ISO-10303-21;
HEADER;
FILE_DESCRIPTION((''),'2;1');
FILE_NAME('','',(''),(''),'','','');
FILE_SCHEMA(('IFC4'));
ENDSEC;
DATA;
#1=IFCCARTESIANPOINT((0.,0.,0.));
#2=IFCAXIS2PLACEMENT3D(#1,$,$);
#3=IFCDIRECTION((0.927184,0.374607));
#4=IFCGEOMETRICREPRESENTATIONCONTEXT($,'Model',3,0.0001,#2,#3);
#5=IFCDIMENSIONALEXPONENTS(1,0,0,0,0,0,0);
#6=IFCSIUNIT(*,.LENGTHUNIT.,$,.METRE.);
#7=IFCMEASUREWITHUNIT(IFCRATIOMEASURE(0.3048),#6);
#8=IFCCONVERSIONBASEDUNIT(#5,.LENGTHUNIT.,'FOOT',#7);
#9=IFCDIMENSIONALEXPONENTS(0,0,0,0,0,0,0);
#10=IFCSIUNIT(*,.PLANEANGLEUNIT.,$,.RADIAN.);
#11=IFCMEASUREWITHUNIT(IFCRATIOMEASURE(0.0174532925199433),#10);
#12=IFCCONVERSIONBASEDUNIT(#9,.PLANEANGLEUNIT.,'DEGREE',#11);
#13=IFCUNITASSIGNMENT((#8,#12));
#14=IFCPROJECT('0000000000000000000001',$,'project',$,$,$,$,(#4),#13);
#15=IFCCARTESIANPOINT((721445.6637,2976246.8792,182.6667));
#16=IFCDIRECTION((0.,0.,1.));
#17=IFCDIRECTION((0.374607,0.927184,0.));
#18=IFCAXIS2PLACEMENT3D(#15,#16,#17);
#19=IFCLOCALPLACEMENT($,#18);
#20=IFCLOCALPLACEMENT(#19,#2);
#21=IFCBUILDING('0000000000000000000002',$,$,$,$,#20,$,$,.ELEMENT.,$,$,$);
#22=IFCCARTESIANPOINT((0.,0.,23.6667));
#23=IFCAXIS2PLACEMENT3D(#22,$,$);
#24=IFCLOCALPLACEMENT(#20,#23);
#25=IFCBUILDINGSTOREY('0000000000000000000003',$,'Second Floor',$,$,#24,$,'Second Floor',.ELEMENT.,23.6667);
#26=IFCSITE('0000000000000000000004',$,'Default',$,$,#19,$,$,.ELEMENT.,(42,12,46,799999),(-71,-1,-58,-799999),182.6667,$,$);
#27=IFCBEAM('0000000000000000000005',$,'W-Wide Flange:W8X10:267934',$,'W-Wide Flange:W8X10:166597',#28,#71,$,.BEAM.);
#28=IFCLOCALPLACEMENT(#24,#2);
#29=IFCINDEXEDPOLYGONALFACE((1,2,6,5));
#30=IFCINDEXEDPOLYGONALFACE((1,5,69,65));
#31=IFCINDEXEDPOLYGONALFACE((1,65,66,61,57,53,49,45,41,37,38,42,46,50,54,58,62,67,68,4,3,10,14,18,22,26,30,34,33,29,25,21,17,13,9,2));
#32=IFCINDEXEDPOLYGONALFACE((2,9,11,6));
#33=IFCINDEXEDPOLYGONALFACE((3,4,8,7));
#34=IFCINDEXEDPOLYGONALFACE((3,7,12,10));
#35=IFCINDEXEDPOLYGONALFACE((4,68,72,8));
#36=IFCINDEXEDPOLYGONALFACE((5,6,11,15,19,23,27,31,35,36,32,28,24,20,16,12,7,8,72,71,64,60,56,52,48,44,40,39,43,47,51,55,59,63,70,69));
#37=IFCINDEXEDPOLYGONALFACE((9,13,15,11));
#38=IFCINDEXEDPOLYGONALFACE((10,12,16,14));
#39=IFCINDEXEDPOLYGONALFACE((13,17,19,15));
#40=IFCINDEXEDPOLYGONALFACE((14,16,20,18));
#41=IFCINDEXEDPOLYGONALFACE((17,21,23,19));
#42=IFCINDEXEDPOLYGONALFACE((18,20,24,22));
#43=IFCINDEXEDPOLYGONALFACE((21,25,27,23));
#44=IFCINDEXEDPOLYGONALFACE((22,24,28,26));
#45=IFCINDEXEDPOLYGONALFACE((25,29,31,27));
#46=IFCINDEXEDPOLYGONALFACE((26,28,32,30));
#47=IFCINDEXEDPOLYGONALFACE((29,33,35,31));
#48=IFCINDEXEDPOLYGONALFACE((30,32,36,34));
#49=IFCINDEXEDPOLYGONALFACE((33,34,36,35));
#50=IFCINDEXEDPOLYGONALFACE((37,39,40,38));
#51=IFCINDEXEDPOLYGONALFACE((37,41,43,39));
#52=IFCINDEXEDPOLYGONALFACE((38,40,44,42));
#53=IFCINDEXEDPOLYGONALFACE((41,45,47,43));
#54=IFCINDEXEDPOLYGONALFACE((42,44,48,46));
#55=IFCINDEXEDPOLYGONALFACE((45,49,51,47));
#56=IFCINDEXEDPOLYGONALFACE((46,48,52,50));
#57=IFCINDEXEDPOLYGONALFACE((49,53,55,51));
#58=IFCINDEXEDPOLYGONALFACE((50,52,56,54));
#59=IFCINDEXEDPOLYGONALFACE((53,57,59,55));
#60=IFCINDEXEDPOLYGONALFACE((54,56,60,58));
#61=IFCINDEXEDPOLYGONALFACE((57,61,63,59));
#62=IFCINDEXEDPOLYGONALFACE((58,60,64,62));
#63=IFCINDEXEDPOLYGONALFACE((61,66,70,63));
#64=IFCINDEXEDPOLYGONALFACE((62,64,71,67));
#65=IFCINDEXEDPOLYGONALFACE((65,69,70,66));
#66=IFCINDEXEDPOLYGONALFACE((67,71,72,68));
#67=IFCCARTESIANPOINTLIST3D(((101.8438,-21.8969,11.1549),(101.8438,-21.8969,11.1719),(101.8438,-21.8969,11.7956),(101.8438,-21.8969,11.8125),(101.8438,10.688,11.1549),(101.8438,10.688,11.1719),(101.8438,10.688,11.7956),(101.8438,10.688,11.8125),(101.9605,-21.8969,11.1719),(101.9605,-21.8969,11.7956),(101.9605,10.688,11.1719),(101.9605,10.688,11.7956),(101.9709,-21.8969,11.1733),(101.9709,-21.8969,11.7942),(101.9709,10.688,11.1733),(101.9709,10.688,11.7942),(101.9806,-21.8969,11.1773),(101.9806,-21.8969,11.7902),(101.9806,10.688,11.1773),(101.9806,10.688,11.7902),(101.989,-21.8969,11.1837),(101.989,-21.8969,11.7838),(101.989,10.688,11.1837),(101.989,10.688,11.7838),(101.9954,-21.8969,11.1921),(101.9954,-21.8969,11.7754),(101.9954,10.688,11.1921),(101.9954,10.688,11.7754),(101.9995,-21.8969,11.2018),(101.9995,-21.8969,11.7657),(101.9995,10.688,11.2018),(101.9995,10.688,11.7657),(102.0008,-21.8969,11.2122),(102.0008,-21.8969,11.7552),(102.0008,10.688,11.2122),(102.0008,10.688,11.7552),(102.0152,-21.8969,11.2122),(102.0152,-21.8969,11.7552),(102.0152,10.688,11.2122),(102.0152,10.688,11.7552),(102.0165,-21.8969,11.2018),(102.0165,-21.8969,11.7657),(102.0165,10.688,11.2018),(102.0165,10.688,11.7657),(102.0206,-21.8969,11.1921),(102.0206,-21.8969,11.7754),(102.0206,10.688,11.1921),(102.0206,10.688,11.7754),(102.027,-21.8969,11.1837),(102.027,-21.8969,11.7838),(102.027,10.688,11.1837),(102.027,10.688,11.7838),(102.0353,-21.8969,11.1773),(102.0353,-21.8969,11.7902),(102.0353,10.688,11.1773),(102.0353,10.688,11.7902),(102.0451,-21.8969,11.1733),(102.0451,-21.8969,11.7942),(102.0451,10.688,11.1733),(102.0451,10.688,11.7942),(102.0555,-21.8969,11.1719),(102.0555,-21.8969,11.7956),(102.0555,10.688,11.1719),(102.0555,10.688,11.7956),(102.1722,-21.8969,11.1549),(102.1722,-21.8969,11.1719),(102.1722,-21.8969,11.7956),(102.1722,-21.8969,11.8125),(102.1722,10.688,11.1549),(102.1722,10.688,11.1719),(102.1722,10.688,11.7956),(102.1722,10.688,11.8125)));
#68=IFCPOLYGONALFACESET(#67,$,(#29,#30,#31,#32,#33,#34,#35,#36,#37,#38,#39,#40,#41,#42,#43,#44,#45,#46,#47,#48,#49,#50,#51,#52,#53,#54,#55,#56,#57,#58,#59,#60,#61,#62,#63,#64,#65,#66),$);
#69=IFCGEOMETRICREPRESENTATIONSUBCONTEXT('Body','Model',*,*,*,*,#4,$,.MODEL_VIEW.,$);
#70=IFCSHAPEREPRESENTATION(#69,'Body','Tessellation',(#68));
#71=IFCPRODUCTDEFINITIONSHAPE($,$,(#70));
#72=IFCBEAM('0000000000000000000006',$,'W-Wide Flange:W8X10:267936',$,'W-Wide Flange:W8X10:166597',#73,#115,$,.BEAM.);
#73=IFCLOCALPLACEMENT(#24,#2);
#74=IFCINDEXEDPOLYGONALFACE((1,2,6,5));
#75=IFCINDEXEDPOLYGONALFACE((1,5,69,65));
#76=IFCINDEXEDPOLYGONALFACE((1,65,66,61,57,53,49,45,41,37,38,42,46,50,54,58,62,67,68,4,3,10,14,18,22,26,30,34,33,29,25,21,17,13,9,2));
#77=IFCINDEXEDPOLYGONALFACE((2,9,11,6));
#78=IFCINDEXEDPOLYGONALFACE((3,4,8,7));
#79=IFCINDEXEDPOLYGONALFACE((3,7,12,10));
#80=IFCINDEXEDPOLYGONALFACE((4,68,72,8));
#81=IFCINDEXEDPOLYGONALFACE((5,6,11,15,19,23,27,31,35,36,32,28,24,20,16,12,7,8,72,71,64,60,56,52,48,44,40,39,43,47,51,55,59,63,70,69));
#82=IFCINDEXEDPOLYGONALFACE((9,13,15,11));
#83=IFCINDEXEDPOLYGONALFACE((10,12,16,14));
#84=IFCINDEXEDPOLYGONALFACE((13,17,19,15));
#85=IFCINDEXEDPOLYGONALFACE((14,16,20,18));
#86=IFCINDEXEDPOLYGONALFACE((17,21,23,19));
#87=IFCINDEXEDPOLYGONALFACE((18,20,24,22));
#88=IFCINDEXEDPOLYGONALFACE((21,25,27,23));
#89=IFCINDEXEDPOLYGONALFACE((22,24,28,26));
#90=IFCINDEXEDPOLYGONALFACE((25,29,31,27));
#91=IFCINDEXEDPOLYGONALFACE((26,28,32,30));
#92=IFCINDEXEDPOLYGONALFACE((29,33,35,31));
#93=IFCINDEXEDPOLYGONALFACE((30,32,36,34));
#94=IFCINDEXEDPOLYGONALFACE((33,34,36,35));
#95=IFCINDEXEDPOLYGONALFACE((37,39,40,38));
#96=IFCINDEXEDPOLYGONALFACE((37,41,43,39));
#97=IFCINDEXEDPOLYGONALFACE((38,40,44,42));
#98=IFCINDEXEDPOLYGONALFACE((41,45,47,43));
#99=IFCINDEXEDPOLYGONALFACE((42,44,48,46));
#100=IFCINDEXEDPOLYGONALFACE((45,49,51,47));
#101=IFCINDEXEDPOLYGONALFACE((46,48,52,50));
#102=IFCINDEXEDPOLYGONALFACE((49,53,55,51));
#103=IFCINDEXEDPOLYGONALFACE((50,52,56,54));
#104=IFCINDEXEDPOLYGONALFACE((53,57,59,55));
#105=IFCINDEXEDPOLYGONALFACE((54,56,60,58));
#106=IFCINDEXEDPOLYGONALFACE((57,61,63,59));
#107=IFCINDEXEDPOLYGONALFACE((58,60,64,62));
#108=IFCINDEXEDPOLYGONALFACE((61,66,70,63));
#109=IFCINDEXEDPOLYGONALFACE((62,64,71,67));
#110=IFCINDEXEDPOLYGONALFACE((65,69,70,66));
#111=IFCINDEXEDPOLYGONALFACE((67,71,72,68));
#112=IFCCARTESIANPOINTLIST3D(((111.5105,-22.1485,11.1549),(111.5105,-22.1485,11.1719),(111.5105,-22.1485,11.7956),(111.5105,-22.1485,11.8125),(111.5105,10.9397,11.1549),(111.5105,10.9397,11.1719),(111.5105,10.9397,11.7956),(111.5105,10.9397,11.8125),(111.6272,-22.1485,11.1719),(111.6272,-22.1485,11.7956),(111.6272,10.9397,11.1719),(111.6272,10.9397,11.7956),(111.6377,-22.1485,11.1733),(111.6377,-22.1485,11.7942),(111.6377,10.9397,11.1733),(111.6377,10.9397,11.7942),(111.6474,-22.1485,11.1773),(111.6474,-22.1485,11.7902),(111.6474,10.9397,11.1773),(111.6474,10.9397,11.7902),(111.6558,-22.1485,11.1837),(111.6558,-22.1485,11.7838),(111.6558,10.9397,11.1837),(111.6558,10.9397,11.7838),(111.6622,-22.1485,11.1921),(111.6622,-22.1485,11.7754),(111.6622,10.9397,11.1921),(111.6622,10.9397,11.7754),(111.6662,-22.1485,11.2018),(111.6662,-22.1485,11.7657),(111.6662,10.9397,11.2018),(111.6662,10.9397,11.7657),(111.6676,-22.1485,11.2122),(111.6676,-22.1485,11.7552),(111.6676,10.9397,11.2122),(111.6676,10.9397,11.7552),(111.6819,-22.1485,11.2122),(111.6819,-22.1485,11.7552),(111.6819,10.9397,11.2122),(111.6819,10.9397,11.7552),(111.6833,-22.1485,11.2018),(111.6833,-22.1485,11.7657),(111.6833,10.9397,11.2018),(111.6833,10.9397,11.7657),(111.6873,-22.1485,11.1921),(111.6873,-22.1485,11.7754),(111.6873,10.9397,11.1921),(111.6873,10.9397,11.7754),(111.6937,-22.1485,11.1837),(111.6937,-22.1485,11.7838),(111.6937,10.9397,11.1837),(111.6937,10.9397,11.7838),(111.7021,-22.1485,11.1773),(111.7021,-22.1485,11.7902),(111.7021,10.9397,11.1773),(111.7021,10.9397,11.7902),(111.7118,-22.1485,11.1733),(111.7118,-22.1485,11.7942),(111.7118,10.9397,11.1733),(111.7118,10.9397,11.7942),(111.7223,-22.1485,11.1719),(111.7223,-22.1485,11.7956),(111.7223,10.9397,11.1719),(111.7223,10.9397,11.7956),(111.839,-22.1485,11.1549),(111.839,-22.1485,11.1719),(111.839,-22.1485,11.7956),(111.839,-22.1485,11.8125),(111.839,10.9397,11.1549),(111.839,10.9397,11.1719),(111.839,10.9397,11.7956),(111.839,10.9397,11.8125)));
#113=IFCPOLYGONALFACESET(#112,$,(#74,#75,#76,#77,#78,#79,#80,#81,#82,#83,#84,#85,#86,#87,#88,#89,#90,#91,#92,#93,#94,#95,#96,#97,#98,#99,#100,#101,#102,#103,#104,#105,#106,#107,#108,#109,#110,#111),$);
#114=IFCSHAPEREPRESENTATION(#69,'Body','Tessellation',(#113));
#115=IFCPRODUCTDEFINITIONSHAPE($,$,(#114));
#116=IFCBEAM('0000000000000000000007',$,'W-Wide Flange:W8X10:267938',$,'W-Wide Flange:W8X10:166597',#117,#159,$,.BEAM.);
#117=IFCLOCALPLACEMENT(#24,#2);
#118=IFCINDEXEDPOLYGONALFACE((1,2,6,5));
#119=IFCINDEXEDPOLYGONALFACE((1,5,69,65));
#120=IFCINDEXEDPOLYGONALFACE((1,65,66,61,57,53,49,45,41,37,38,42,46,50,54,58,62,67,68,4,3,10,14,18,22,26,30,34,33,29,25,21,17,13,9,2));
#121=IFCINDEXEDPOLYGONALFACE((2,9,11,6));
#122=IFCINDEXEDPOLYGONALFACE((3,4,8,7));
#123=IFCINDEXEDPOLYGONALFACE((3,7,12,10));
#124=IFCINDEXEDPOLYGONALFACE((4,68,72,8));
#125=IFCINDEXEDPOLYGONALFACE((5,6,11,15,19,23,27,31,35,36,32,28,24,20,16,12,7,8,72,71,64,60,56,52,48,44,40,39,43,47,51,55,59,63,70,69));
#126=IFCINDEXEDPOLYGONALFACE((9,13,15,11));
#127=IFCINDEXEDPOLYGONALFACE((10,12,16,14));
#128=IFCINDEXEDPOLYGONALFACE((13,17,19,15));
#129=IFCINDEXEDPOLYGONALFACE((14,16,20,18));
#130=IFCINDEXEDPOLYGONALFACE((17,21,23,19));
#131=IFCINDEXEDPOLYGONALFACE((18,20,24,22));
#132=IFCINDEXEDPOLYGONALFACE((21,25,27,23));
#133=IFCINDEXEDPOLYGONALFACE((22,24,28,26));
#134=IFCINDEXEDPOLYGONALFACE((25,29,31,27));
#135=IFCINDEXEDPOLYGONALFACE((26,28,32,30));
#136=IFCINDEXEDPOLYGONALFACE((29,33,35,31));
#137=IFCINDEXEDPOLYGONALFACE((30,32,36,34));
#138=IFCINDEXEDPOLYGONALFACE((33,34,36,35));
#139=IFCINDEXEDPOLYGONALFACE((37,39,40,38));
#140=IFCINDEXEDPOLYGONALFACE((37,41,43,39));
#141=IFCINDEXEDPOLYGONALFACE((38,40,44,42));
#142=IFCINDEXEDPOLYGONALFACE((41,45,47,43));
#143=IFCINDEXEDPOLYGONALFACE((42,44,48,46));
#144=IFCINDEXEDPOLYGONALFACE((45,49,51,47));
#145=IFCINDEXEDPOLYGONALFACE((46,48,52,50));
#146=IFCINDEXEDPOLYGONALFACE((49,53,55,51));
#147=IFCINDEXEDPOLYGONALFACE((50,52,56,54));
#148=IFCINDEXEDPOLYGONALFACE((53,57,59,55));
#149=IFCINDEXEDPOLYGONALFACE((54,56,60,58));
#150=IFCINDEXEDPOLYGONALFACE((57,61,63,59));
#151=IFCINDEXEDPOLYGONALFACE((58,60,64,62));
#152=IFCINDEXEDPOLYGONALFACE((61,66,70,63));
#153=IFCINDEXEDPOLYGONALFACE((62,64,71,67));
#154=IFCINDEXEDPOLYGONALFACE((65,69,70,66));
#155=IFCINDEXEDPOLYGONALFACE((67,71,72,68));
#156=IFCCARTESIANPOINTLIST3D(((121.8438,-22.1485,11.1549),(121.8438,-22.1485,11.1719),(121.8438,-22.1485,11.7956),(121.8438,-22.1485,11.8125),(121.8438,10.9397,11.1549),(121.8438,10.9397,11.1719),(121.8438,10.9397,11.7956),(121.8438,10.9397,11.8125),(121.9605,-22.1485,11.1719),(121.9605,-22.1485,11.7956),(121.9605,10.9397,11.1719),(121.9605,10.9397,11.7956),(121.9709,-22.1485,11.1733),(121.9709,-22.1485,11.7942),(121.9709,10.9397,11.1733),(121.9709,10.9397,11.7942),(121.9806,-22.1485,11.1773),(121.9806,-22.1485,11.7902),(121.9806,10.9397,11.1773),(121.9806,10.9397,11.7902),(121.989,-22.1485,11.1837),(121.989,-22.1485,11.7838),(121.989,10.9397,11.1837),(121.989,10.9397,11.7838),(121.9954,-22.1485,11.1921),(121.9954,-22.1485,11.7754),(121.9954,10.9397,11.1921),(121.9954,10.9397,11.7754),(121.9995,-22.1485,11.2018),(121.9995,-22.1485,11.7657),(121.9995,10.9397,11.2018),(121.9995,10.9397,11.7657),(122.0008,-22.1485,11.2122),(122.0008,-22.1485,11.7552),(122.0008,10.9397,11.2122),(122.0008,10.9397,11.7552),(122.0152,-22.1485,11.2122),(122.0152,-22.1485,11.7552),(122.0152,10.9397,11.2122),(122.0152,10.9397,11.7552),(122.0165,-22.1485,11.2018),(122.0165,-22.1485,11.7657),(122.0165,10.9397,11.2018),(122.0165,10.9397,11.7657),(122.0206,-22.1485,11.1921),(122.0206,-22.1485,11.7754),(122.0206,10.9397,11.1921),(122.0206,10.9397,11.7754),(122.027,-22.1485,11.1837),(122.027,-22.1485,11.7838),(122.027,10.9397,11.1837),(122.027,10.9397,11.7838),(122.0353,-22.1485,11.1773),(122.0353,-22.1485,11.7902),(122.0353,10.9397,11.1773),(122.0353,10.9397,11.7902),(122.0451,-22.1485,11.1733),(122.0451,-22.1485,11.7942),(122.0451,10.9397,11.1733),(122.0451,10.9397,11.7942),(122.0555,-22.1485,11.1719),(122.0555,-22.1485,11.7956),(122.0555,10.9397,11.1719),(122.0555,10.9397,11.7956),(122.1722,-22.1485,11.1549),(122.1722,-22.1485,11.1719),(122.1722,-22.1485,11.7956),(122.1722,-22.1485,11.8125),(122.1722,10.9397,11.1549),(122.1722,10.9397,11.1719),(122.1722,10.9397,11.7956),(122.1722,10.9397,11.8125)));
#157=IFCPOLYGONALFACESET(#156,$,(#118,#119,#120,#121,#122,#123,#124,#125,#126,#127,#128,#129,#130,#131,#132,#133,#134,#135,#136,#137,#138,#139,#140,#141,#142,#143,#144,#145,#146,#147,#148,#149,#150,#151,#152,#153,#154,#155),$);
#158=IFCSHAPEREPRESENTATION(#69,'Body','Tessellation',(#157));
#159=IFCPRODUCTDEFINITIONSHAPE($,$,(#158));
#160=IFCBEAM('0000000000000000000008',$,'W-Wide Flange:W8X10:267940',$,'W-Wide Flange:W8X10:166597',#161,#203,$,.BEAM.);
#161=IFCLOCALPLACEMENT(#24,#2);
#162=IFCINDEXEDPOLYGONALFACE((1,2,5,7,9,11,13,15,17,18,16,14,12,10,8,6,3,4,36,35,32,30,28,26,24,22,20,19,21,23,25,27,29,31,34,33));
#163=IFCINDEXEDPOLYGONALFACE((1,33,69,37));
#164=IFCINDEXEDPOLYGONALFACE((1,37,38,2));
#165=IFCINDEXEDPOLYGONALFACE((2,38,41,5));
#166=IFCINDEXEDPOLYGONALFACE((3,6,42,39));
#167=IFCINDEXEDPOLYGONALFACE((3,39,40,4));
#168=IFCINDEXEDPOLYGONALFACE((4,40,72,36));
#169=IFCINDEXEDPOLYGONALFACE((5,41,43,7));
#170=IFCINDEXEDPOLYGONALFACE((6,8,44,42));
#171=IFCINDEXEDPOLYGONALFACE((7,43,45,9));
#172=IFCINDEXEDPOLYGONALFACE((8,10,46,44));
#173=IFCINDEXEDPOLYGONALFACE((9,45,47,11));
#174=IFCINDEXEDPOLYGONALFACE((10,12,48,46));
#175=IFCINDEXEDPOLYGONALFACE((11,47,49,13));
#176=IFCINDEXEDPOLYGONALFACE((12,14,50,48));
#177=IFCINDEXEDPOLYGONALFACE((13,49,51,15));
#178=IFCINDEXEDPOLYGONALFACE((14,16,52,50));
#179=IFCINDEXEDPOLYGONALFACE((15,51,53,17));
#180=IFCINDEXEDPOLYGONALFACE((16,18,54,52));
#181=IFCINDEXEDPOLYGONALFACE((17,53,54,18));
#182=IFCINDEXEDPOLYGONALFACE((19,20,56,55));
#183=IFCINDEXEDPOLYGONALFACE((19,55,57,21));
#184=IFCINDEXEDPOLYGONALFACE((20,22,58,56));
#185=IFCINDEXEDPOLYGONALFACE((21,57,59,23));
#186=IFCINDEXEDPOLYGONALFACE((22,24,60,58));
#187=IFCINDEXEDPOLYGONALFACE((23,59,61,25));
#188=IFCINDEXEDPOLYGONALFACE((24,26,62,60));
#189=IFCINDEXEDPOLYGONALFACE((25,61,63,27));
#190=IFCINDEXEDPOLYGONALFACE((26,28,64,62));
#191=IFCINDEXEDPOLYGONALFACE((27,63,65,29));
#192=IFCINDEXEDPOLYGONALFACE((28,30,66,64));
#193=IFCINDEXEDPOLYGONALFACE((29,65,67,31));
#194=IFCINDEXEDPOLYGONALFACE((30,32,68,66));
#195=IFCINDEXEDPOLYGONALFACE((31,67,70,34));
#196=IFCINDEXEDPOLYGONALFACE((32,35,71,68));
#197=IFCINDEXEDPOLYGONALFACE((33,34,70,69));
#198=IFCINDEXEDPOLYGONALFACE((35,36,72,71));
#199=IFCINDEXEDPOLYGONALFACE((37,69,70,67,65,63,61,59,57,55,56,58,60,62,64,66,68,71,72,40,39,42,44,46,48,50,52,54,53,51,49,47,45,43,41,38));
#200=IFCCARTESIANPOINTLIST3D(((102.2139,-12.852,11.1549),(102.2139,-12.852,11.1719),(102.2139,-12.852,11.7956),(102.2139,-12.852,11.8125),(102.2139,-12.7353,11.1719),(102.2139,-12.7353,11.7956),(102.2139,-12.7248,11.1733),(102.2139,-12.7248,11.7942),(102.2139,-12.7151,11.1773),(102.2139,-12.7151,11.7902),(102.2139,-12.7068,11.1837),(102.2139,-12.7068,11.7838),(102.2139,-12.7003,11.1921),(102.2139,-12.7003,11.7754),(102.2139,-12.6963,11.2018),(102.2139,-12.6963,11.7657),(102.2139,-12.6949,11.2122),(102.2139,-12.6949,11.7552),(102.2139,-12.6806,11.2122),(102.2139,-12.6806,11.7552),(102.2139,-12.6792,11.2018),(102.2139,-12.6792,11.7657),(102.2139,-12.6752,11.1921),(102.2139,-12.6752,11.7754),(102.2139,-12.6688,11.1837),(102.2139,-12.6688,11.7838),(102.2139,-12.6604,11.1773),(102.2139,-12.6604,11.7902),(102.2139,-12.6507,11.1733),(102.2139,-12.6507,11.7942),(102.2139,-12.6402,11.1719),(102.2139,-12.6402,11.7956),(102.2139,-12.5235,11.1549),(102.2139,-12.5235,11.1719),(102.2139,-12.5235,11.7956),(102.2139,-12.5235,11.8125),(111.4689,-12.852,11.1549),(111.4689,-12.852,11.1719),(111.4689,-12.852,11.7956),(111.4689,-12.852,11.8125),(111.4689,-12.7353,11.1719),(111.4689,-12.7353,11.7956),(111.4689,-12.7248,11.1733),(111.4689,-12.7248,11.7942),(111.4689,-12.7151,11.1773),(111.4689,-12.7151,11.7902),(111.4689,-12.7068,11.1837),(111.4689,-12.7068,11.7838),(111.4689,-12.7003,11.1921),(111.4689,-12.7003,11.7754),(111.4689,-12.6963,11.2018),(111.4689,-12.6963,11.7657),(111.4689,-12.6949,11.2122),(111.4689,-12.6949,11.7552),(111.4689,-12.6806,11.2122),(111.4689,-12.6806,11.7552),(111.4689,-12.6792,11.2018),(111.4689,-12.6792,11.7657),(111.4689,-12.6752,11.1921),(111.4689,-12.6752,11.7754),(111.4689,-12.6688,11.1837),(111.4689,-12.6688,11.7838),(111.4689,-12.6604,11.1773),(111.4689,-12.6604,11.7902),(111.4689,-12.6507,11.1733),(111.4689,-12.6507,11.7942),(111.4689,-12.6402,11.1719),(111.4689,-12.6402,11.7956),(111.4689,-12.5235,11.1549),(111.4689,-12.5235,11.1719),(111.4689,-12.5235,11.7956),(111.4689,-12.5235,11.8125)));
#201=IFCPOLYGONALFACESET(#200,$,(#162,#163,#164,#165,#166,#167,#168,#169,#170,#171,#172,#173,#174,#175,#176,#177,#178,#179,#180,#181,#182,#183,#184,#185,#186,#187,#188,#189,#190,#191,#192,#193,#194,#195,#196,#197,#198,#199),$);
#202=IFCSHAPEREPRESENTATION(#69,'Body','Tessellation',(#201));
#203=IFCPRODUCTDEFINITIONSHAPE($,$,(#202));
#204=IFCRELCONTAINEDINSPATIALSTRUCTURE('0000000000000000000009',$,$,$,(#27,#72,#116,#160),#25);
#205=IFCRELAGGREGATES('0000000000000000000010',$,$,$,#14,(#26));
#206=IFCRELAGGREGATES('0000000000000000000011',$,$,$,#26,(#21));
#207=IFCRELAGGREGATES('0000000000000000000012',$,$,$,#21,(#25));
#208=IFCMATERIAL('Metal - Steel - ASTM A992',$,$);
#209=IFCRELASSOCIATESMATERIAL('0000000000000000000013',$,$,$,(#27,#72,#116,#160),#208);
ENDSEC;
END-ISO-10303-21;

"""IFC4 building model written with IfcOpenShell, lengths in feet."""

from ifc_helpers import new_model, entity, si_unit, converted_unit, direction, frame, frame_2d, origin, place, context, subcontext, project, spatial, i_section, extrude, material, element, save


model = new_model("IFC4")

# Units and contexts
model_context = context("Model", 3, precision=0.0001, world=origin(), true_north=direction((0.927184, 0.374607)))
body_context = subcontext(model_context, "Body", "Model", "MODEL_VIEW")
ifc_project = project(units=[converted_unit("LENGTHUNIT", "FOOT", entity("IfcRatioMeasure", 0.3048), si_unit("LENGTHUNIT", "METRE"), dimensions=[1, 0, 0, 0, 0, 0, 0]), converted_unit("PLANEANGLEUNIT", "DEGREE", entity("IfcRatioMeasure", 0.0174532925199433), si_unit("PLANEANGLEUNIT", "RADIAN"), dimensions=[0, 0, 0, 0, 0, 0, 0])], contexts=[model_context])

# Site, building, storey
site_placement = place(None, frame((721445.6637, 2976246.8792, 182.6667), z_axis=(0.0, 0.0, 1.0), x_axis=(0.374607, 0.927184, 0.0)))
site = spatial("IfcSite", under=ifc_project, at=site_placement, Name="Default", CompositionType="ELEMENT", RefLatitude=(42, 12, 46, 799999), RefLongitude=(-71, -1, -58, -799999), RefElevation=182.6667)
building_placement = place(site_placement, origin())
building = spatial("IfcBuilding", under=site, at=building_placement, CompositionType="ELEMENT")
storey_placement = place(building_placement, frame((0.0, 0.0, 23.6667)))
storey = spatial("IfcBuildingStorey", under=building, at=storey_placement, Name="Second Floor", LongName="Second Floor", CompositionType="ELEMENT", Elevation=23.6667)

# Shared definitions
ifc_material_1 = material(Name="Metal - Steel - ASTM A992")

# Beams
beam_1_placement = place(storey_placement, frame((102.008, 11.1456, 11.8125), z_axis=(0.0, 0.0, 1.0), x_axis=(0.0, -1.0, 0.0)))
element("IfcBeam", 1, at=beam_1_placement, inside=storey, material=ifc_material_1, Name="W-Wide Flange:W8X10:267934", ObjectType="W-Wide Flange:W8X10:166597", PredefinedType="BEAM", context=body_context, shape_type="SweptSolid", body=[
    extrude(i_section(OverallWidth=0.3285, OverallDepth=0.6576, WebThickness=0.0143, FlangeThickness=0.0169, FilletRadius=0.0404, at=frame_2d((0.0, 0.0), x_axis=(0.0, 1.0))), frame((0.4575, 0.0, -0.3288), z_axis=(1.0, 0.0, 0.0), x_axis=(0.0, 0.0, -1.0)), (0.0, 0.0, 1.0), 32.585),
])
for number, where, z_axis, x_axis, name in (
    (2, (111.6748, 11.1456, 11.8125), (0.0, 0.0, 1.0), (0.0, -1.0, 0.0), "W-Wide Flange:W8X10:267936"),
    (3, (122.008, 11.1456, 11.8125), (0.0, 0.0, 1.0), (0.0, -1.0, 0.0), "W-Wide Flange:W8X10:267938"),
):
    element("IfcBeam", number, at=place(storey_placement, frame(where, z_axis=z_axis, x_axis=x_axis)), inside=storey, material=ifc_material_1, Name=name, ObjectType="W-Wide Flange:W8X10:166597", PredefinedType="BEAM", context=body_context, shape_type="SweptSolid", body=[
        extrude(i_section(OverallWidth=0.3285, OverallDepth=0.6576, WebThickness=0.0143, FlangeThickness=0.0169, FilletRadius=0.0404, at=frame_2d((0.0, 0.0), x_axis=(0.0, 1.0))), frame((0.2059, 0.0, -0.3288), z_axis=(1.0, 0.0, 0.0), x_axis=(0.0, 0.0, -1.0)), (0.0, 0.0, 1.0), 33.0882),
    ])
beam_2_placement = place(storey_placement, frame((102.008, -12.6878, 11.8125)))
element("IfcBeam", 4, at=beam_2_placement, inside=storey, material=ifc_material_1, Name="W-Wide Flange:W8X10:267940", ObjectType="W-Wide Flange:W8X10:166597", PredefinedType="BEAM", context=body_context, shape_type="SweptSolid", body=[
    extrude(i_section(OverallWidth=0.3285, OverallDepth=0.6576, WebThickness=0.0143, FlangeThickness=0.0169, FilletRadius=0.0404, at=frame_2d((0.0, 0.0), x_axis=(0.0, 1.0))), frame((0.2059, 0.0, -0.3288), z_axis=(1.0, 0.0, 0.0), x_axis=(0.0, 0.0, -1.0)), (0.0, 0.0, 1.0), 9.255),
])

save(model, "model.ifc")
